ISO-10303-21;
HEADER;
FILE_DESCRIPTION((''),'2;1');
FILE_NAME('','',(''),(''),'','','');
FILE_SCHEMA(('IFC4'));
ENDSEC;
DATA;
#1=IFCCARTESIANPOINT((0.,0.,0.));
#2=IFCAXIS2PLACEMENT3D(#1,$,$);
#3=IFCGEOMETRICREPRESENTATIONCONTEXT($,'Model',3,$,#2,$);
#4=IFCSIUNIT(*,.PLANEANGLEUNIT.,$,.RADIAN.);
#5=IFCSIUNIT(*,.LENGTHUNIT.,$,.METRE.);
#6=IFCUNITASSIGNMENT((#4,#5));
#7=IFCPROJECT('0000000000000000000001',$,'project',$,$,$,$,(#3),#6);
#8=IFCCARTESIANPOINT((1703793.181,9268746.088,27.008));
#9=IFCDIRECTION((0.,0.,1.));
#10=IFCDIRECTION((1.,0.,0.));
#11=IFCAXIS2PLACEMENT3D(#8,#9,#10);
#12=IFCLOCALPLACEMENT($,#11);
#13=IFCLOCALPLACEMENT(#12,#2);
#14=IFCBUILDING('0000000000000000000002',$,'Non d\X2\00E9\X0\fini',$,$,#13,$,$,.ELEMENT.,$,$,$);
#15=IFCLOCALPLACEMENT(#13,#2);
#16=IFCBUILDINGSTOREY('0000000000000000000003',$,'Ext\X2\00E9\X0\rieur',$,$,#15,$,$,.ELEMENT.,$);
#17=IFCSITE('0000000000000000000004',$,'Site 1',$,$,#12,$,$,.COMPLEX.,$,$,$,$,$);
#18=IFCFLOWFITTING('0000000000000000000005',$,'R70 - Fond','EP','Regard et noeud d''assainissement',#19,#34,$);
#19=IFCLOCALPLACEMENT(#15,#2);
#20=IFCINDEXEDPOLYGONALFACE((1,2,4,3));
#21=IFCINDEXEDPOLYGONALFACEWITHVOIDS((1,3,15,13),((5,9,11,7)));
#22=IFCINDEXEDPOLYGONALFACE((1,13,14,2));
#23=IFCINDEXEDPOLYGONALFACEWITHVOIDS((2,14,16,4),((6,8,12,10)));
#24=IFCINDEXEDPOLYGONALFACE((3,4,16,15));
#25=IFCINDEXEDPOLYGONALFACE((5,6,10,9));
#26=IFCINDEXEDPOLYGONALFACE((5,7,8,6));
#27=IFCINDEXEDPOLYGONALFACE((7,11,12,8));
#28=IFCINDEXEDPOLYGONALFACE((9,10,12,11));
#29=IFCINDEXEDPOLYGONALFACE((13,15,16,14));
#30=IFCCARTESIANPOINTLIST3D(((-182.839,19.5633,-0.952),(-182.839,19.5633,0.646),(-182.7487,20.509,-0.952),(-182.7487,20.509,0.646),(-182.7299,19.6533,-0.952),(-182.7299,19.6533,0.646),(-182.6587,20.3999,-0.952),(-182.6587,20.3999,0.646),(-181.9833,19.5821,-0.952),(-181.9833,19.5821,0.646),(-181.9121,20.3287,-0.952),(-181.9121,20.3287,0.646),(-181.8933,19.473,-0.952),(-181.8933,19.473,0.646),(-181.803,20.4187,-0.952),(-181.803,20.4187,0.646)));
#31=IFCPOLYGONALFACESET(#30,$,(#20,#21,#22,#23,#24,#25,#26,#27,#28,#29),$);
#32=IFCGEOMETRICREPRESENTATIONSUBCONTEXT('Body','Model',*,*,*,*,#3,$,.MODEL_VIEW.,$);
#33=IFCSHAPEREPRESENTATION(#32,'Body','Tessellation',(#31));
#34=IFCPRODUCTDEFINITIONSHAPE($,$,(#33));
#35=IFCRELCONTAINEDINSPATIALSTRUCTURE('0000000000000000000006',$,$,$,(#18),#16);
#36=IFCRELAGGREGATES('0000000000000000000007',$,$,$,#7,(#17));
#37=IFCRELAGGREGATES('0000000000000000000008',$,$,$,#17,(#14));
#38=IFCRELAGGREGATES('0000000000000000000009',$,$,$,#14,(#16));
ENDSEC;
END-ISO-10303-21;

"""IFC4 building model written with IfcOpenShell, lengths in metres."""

from ifc_helpers import new_model, si_unit, frame, origin, origin_2d, place, context, subcontext, project, spatial, hollow_rectangle, extrude, element, save


model = new_model("IFC4")

# Units and contexts
model_context = context("Model", 3, world=origin())
body_context = subcontext(model_context, "Body", "Model", "MODEL_VIEW")
ifc_project = project(units=[si_unit("PLANEANGLEUNIT", "RADIAN"), si_unit("LENGTHUNIT", "METRE")], contexts=[model_context])

# Site, building, storey
site_placement = place(None, frame((1703793.181, 9268746.088, 27.008), z_axis=(0.0, 0.0, 1.0), x_axis=(1.0, 0.0, 0.0)))
site = spatial("IfcSite", under=ifc_project, at=site_placement, Name="Site 1", CompositionType="COMPLEX")
building_placement = place(site_placement, origin())
building = spatial("IfcBuilding", under=site, at=building_placement, Name="Non défini", CompositionType="ELEMENT")
storey_placement = place(building_placement, origin())
storey = spatial("IfcBuildingStorey", under=building, at=storey_placement, Name="Extérieur", CompositionType="ELEMENT")

# Flow fitting
flow_fitting_1_placement = place(storey_placement, origin())
element("IfcFlowFitting", 1, at=flow_fitting_1_placement, inside=storey, Name="R70 - Fond", Description="EP", ObjectType="Regard et noeud d'assainissement", context=body_context, shape_type="SweptSolid", body=[
    extrude(hollow_rectangle(XDim=0.95, YDim=0.95, WallThickness=0.1, at=origin_2d()), frame((-182.321, 19.991, -0.952), z_axis=(0.0, 0.0, 1.0), x_axis=(-0.095, -0.995, 0.0)), (0.0, 0.0, 1.0), 1.598),
])

save(model, "model.ifc")
